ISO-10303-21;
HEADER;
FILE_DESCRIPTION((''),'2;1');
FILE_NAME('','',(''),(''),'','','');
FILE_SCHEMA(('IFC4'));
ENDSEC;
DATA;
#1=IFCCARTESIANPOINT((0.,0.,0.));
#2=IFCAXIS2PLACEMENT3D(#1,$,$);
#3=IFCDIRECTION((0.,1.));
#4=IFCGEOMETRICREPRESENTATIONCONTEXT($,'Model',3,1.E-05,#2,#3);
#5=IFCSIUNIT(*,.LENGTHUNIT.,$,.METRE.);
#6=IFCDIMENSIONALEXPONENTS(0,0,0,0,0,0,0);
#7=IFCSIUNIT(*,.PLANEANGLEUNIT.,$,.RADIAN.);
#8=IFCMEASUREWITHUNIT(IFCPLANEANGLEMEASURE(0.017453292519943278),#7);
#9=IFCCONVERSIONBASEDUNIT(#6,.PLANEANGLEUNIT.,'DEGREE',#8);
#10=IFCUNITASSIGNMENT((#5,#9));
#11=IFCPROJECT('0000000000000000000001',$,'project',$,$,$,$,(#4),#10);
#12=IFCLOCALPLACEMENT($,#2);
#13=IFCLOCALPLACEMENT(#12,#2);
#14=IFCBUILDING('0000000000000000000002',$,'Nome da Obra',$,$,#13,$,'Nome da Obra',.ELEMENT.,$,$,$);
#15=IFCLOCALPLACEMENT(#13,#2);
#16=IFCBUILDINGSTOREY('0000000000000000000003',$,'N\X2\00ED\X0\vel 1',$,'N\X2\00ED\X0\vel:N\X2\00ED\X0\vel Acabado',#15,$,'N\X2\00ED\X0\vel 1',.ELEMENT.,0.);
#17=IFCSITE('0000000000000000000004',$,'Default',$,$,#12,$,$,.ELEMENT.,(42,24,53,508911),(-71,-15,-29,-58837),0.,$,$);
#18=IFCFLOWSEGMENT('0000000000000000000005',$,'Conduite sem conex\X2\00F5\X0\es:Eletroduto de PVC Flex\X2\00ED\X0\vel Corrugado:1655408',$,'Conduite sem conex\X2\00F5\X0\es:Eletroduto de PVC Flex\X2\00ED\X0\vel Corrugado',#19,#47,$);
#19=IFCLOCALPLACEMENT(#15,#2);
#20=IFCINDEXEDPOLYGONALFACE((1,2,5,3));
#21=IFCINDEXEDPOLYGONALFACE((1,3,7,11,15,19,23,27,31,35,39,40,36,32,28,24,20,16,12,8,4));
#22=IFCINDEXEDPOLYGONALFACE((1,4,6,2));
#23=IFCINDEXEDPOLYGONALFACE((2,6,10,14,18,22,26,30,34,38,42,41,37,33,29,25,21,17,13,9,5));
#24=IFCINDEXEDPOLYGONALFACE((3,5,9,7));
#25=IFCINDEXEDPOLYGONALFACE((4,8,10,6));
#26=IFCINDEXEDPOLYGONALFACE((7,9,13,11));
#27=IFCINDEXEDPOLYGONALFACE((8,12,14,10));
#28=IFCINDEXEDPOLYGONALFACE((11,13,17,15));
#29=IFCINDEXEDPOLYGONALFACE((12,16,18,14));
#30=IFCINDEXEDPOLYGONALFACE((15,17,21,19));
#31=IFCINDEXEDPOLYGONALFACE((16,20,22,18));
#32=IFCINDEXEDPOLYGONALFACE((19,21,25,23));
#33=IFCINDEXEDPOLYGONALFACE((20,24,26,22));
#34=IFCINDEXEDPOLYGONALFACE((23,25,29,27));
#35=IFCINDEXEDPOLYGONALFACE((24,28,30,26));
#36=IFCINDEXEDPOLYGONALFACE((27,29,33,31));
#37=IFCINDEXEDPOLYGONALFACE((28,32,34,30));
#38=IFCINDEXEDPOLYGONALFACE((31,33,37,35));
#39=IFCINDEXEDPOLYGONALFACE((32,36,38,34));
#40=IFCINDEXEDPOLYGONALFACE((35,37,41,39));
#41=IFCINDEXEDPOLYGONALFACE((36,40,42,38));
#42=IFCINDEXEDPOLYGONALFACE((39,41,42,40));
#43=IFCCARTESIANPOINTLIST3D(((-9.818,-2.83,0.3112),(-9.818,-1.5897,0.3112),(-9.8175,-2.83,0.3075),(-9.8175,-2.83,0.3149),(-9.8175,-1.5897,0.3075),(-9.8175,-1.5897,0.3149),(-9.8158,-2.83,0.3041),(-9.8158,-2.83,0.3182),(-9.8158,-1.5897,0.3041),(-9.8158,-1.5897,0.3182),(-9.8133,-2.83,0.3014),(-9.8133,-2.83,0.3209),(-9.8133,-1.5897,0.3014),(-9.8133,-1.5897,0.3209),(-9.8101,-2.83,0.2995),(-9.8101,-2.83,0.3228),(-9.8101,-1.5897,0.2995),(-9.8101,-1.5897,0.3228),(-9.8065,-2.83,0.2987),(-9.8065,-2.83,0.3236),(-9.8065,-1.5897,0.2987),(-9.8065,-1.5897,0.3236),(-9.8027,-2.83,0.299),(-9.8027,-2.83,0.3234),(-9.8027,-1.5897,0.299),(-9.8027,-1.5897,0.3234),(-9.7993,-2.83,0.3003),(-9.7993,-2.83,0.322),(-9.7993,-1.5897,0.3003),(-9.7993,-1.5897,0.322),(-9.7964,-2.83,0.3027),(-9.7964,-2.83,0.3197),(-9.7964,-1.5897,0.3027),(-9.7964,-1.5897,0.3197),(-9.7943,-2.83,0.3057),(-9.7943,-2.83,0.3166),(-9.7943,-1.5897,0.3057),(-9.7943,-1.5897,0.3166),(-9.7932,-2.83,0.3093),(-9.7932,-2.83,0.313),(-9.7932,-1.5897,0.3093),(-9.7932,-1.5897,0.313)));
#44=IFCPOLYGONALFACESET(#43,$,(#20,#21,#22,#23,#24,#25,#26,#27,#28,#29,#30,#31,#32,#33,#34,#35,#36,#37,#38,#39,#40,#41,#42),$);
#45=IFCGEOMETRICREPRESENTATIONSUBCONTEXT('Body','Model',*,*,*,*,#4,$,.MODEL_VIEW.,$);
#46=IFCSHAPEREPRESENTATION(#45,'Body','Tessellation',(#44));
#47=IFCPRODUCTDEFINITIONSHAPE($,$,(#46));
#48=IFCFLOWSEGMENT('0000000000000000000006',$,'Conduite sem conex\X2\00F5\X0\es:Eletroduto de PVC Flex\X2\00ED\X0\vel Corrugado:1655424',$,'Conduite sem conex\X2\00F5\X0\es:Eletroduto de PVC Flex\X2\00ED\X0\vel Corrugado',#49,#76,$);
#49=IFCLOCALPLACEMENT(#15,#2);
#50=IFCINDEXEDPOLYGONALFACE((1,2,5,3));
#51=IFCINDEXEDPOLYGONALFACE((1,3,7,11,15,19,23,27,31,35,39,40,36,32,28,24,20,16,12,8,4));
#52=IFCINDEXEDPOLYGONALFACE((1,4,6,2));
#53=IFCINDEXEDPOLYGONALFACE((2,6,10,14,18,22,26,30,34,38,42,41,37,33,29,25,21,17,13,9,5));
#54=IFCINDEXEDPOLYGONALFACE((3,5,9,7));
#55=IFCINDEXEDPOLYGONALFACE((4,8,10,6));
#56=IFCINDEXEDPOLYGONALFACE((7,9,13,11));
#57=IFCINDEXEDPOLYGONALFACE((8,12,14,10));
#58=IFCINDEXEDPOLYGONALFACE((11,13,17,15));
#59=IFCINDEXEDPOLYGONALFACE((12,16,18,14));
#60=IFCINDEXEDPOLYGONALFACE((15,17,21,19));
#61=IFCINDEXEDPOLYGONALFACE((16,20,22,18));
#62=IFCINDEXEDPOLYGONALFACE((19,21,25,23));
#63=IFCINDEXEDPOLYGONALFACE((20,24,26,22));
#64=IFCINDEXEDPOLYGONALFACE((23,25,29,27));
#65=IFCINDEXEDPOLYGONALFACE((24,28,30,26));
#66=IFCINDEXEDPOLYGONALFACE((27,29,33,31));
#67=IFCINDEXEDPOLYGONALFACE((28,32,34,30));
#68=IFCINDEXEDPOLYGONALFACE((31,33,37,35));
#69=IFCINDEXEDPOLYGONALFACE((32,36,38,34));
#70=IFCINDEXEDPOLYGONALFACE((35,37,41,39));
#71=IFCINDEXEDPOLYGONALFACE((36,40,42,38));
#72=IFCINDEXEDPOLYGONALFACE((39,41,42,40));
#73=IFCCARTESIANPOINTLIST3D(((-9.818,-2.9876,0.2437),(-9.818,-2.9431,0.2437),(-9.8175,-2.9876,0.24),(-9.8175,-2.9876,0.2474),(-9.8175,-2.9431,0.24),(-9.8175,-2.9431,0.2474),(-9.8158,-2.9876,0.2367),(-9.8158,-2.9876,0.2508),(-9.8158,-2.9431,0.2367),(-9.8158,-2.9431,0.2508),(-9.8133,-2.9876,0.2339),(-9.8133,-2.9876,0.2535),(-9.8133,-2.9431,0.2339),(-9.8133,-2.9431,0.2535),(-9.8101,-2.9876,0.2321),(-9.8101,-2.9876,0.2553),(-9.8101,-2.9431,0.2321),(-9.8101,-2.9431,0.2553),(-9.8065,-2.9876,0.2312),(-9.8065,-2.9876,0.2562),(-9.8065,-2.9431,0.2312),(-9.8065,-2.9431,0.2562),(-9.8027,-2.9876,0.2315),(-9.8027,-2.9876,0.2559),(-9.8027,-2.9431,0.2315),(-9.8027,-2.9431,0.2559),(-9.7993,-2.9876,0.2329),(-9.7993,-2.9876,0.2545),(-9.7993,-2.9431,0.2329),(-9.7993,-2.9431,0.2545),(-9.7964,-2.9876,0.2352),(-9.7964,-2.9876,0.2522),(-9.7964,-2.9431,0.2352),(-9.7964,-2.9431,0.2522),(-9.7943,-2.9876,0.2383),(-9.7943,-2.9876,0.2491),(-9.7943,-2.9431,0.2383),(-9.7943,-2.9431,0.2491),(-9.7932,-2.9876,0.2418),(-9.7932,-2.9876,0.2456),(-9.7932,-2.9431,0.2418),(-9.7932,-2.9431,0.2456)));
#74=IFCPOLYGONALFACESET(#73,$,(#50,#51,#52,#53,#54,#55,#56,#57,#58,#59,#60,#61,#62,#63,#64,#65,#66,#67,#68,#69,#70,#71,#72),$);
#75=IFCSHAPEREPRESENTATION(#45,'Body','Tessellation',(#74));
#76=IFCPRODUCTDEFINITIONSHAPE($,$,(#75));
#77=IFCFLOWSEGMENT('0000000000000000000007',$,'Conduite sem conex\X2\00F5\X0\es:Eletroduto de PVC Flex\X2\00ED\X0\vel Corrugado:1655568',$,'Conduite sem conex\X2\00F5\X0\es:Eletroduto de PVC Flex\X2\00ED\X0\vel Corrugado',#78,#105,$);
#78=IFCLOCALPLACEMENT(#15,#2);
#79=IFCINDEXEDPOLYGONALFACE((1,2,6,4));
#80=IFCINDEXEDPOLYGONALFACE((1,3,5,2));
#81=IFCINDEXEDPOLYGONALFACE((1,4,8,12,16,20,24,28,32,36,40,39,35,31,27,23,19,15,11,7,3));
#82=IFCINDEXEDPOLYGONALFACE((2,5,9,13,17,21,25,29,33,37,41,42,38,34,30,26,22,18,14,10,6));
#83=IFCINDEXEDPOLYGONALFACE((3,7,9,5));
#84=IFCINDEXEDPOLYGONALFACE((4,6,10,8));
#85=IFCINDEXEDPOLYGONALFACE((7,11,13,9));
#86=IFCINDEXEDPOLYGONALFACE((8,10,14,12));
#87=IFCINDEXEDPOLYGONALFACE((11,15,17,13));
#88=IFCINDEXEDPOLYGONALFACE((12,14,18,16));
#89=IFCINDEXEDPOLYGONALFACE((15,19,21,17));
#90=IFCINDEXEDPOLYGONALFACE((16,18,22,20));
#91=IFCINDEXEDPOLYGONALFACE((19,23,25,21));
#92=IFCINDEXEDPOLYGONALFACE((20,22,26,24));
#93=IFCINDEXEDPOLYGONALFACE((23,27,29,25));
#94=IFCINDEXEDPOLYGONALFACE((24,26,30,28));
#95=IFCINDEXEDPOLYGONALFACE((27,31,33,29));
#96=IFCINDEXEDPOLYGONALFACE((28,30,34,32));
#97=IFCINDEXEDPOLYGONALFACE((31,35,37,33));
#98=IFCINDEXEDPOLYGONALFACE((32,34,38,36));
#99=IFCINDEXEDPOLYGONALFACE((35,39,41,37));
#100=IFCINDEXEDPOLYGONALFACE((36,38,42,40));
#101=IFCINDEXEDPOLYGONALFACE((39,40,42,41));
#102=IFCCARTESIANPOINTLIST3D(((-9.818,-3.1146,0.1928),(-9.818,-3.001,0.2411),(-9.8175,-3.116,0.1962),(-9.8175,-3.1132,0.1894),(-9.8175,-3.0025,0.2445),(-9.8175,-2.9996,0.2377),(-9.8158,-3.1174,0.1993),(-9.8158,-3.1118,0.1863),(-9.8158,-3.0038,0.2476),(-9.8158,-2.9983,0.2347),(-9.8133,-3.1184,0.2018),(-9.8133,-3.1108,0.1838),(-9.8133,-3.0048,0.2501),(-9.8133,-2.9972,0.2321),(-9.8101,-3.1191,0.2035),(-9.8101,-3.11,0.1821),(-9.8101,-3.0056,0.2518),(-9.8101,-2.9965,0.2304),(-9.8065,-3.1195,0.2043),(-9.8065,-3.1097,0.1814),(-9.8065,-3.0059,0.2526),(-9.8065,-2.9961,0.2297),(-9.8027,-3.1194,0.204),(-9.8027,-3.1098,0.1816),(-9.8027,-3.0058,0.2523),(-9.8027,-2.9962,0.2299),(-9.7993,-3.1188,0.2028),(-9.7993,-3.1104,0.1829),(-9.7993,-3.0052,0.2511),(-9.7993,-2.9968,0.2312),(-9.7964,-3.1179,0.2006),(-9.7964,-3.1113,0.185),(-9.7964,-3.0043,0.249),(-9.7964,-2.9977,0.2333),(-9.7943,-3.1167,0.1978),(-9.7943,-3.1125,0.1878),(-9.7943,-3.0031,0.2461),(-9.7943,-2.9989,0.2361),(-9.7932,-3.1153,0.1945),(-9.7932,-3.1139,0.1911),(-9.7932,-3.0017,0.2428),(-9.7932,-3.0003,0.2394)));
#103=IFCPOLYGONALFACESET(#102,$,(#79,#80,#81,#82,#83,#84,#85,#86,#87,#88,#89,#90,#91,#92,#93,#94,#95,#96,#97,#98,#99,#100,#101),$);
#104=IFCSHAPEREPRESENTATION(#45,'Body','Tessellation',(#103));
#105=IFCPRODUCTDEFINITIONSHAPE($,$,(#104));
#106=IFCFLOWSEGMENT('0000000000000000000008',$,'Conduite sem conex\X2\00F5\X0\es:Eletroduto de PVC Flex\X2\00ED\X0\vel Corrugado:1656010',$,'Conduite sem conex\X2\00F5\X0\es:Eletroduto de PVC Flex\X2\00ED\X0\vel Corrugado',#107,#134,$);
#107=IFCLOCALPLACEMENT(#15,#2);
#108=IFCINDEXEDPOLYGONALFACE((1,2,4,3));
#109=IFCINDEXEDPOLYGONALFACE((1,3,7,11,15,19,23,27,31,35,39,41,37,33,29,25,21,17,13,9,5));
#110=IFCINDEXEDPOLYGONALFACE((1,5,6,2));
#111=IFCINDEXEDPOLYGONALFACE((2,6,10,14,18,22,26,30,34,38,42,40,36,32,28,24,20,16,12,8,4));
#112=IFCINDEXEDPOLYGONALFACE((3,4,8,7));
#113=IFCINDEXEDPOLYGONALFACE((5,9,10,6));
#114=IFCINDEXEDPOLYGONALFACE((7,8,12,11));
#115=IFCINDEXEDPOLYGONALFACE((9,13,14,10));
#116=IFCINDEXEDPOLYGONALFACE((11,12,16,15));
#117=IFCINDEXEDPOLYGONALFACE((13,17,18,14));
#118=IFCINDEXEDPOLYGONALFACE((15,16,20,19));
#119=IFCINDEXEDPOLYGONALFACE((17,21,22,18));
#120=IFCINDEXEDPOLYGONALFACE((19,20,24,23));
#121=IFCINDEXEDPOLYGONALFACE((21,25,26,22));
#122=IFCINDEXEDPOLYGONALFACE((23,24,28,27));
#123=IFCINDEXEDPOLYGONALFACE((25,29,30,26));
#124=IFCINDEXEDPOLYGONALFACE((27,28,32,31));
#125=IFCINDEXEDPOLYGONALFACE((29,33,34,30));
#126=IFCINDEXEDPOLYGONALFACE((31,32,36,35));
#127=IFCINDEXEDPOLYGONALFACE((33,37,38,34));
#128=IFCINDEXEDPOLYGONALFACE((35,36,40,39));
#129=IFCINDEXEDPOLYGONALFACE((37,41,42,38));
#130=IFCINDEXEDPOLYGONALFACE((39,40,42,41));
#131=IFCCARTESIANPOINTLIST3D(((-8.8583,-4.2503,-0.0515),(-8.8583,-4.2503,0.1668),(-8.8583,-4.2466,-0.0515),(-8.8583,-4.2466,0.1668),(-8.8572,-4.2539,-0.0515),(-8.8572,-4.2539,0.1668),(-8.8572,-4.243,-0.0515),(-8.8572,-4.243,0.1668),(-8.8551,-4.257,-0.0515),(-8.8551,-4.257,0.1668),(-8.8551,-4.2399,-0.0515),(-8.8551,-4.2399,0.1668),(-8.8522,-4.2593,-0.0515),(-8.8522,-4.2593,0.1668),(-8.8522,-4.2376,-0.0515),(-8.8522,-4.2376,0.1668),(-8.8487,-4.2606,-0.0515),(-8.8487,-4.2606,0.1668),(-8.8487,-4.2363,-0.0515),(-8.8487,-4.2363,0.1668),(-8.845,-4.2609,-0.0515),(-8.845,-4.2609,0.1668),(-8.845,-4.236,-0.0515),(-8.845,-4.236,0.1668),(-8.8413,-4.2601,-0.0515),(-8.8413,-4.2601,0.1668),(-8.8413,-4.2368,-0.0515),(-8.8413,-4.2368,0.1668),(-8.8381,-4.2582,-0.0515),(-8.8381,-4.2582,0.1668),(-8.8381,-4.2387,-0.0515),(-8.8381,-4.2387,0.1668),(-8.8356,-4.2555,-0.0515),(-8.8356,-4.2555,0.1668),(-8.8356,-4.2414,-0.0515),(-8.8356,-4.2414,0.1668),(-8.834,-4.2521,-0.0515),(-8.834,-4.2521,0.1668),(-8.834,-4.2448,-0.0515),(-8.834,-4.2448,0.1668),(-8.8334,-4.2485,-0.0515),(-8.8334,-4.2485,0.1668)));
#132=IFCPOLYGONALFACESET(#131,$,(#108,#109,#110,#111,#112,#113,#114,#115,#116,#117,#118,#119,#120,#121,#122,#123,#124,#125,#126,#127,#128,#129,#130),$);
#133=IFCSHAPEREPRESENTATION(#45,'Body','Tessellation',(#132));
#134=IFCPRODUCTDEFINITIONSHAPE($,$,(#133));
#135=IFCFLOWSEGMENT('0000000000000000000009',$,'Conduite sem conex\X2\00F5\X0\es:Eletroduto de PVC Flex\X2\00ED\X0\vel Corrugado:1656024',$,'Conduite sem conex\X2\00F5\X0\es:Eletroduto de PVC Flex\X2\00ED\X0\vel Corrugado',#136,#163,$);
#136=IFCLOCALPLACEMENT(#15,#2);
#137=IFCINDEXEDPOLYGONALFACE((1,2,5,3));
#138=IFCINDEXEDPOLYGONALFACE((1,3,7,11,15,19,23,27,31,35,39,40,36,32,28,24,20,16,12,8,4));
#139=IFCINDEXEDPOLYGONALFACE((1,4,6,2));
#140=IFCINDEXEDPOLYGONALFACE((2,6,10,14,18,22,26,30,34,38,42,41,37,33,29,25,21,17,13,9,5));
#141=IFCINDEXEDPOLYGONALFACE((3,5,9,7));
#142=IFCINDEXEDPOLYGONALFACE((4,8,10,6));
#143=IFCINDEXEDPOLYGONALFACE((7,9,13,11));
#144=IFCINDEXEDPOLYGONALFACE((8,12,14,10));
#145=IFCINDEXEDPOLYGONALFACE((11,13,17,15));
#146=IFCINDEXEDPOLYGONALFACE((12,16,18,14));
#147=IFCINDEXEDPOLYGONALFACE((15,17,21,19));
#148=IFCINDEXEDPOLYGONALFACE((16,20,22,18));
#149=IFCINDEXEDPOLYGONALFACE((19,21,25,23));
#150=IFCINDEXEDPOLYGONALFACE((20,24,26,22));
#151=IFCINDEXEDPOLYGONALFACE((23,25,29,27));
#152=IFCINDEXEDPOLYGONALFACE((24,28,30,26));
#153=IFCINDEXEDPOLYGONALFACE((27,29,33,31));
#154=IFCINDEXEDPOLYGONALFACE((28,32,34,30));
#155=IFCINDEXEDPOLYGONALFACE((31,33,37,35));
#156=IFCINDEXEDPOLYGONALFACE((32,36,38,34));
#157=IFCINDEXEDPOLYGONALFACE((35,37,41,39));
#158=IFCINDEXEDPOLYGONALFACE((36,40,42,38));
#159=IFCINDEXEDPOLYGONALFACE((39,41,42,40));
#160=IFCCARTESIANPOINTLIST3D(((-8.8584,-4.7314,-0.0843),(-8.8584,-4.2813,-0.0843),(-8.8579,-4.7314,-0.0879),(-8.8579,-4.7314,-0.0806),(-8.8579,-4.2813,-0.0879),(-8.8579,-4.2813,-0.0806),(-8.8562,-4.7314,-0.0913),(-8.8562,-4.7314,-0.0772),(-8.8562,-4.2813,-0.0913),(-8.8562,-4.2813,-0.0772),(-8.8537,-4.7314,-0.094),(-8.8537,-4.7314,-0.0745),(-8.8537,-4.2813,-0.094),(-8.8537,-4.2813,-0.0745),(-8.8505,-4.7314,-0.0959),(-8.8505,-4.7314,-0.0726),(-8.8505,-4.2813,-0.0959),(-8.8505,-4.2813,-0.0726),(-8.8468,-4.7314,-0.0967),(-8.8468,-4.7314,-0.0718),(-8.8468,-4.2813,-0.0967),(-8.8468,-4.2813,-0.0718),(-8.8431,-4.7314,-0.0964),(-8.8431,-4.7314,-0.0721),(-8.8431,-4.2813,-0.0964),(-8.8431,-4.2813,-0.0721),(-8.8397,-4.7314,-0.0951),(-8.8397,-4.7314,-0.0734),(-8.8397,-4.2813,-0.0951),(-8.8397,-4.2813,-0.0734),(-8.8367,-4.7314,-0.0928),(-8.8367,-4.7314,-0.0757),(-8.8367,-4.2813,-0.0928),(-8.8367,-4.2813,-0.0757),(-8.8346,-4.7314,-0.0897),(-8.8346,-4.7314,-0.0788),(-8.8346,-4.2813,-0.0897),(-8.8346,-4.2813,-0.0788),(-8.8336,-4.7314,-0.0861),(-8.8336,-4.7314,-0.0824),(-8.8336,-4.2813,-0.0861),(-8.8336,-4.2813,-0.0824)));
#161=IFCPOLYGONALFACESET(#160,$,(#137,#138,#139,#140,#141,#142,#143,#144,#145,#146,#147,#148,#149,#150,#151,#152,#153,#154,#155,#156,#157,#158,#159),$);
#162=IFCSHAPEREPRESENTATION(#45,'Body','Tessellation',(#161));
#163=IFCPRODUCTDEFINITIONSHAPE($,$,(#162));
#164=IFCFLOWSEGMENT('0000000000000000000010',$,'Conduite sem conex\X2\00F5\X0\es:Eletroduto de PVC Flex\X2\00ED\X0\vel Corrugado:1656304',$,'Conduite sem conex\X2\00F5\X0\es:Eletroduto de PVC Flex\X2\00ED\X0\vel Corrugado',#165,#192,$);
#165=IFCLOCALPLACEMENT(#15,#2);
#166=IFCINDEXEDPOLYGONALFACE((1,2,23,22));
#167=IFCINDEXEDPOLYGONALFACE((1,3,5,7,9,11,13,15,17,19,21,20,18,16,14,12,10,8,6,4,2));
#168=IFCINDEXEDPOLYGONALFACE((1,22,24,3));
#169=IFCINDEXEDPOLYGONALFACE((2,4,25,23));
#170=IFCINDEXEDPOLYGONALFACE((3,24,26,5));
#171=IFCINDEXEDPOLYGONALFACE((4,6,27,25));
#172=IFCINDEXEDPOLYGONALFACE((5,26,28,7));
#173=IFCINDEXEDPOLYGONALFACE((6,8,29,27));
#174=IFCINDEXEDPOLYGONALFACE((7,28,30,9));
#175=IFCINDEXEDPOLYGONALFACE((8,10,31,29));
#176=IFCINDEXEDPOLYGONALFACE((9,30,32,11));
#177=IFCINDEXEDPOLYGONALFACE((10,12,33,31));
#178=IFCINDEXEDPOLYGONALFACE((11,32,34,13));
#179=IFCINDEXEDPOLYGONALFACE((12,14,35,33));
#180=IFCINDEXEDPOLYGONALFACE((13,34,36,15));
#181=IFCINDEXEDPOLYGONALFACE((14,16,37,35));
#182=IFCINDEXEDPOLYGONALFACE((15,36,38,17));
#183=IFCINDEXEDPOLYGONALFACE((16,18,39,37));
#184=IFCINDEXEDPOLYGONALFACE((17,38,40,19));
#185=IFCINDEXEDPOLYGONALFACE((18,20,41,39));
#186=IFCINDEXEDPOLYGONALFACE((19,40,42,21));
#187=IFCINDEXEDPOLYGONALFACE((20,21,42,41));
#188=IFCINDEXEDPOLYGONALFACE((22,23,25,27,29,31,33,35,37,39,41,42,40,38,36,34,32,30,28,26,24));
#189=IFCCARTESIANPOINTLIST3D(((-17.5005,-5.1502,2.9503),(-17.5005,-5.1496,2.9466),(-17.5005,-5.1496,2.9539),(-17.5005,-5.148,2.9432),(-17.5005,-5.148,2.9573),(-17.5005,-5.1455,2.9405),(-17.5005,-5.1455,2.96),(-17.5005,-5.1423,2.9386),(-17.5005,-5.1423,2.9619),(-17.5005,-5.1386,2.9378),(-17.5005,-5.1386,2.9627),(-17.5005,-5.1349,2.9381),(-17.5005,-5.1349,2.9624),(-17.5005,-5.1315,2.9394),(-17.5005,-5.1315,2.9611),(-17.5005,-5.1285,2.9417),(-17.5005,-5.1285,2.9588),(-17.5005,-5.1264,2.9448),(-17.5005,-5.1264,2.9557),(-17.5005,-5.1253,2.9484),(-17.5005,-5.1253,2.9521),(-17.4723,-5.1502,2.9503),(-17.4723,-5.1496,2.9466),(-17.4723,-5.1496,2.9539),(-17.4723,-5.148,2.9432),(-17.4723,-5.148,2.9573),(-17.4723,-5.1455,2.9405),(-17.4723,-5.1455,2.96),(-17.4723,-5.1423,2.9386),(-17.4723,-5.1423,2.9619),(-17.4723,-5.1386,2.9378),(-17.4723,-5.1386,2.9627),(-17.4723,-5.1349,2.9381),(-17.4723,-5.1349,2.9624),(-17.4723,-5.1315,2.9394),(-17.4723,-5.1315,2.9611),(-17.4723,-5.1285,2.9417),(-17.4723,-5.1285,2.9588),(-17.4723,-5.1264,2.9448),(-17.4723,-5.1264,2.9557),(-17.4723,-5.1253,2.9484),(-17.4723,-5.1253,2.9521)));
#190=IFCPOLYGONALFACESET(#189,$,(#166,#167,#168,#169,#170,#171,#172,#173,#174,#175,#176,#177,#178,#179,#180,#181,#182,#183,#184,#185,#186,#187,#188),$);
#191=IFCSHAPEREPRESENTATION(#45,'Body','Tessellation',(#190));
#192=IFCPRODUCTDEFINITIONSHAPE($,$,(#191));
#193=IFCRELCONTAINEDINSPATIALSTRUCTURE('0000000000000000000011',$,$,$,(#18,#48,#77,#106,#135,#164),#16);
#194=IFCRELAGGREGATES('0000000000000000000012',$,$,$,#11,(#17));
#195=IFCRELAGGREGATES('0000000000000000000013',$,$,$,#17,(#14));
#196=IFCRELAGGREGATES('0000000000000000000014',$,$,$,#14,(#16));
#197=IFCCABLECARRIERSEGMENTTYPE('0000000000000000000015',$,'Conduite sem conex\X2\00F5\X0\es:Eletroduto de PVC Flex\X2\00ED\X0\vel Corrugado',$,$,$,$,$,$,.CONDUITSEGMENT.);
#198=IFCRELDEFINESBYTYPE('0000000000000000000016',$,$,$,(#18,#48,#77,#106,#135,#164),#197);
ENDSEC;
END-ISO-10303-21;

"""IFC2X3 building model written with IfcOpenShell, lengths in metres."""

from ifc_helpers import new_model, entity, si_unit, converted_unit, direction, frame, frame_2d, origin, origin_2d_with_axis, place, context, subcontext, project, spatial, circle, extrude, type_object, element, save


model = new_model("IFC2X3")

# Units and contexts
model_context = context("Model", 3, precision=1e-05, world=origin(), true_north=direction((0.0, 1.0)))
body_context = subcontext(model_context, "Body", "Model", "MODEL_VIEW")
ifc_project = project(units=[si_unit("LENGTHUNIT", "METRE"), converted_unit("PLANEANGLEUNIT", "DEGREE", entity("IfcPlaneAngleMeasure", 0.017453292519943278), si_unit("PLANEANGLEUNIT", "RADIAN"), dimensions=[0, 0, 0, 0, 0, 0, 0])], contexts=[model_context])

# Site, building, storey
site_placement = place(None, origin())
site = spatial("IfcSite", under=ifc_project, at=site_placement, Name="Default", CompositionType="ELEMENT", RefLatitude=(42, 24, 53, 508911), RefLongitude=(-71, -15, -29, -58837), RefElevation=0.0)
building_placement = place(site_placement, origin())
building = spatial("IfcBuilding", under=site, at=building_placement, Name="Nome da Obra", LongName="Nome da Obra", CompositionType="ELEMENT")
storey_placement = place(building_placement, origin())
storey = spatial("IfcBuildingStorey", under=building, at=storey_placement, Name="Nível 1", ObjectType="Nível:Nível Acabado", LongName="Nível 1", CompositionType="ELEMENT", Elevation=0.0)

# Flow segments
cable_carrier_segment_type = type_object("IfcCableCarrierSegmentType", Name="Conduite sem conexões:Eletroduto de PVC Flexível Corrugado", PredefinedType="CONDUITSEGMENT")
flow_segment_1_placement = place(storey_placement, origin())
element("IfcFlowSegment", 1, at=flow_segment_1_placement, inside=storey, type_object=cable_carrier_segment_type, Name="Conduite sem conexões:Eletroduto de PVC Flexível Corrugado:1655408", ObjectType="Conduite sem conexões:Eletroduto de PVC Flexível Corrugado", context=body_context, shape_type="SweptSolid", body=[
    extrude(circle(Radius=0.0125, at=frame_2d((0.0, 0.0), x_axis=(1.0, 0.0))), frame((-9.8055, -2.83, 0.3112), z_axis=(0.000002, 1.0, 0.0), x_axis=(-1.0, 0.000002, 0.0)), (0.0, 0.0, 1.0), 1.2403),
])
flow_segment_2_placement = place(storey_placement, origin())
element("IfcFlowSegment", 2, at=flow_segment_2_placement, inside=storey, type_object=cable_carrier_segment_type, Name="Conduite sem conexões:Eletroduto de PVC Flexível Corrugado:1655424", ObjectType="Conduite sem conexões:Eletroduto de PVC Flexível Corrugado", context=body_context, shape_type="SweptSolid", body=[
    extrude(circle(Radius=0.0125, at=frame_2d((0.0, 0.0), x_axis=(1.0, 0.0))), frame((-9.8055, -2.9876, 0.2437), z_axis=(0.0, 1.0, 0.0), x_axis=(-1.0, 0.0, 0.0)), (0.0, 0.0, 1.0), 0.0445),
])
flow_segment_3_placement = place(storey_placement, origin())
element("IfcFlowSegment", 3, at=flow_segment_3_placement, inside=storey, type_object=cable_carrier_segment_type, Name="Conduite sem conexões:Eletroduto de PVC Flexível Corrugado:1655568", ObjectType="Conduite sem conexões:Eletroduto de PVC Flexível Corrugado", context=body_context, shape_type="SweptSolid", body=[
    extrude(circle(Radius=0.0125, at=origin_2d_with_axis()), frame((-9.8055, -3.1146, 0.1928), z_axis=(0.0, 0.920228, 0.391382), x_axis=(-1.0, 0.0, 0.0)), (0.0, 0.0, 1.0), 0.1234),
])
flow_segment_4_placement = place(storey_placement, origin())
element("IfcFlowSegment", 4, at=flow_segment_4_placement, inside=storey, type_object=cable_carrier_segment_type, Name="Conduite sem conexões:Eletroduto de PVC Flexível Corrugado:1656010", ObjectType="Conduite sem conexões:Eletroduto de PVC Flexível Corrugado", context=body_context, shape_type="SweptSolid", body=[
    extrude(circle(Radius=0.0125, at=frame_2d((0.0, 0.0), x_axis=(1.0, 0.0))), frame((-8.8459, -4.2485, -0.0515)), (0.0, 0.0, 1.0), 0.2182),
])
flow_segment_5_placement = place(storey_placement, origin())
element("IfcFlowSegment", 5, at=flow_segment_5_placement, inside=storey, type_object=cable_carrier_segment_type, Name="Conduite sem conexões:Eletroduto de PVC Flexível Corrugado:1656024", ObjectType="Conduite sem conexões:Eletroduto de PVC Flexível Corrugado", context=body_context, shape_type="SweptSolid", body=[
    extrude(circle(Radius=0.0125, at=frame_2d((0.0, 0.0), x_axis=(1.0, 0.0))), frame((-8.8459, -4.7314, -0.0843), z_axis=(-0.000001, 1.0, 0.0), x_axis=(-1.0, -0.000001, 0.0)), (0.0, 0.0, 1.0), 0.4501),
])
flow_segment_6_placement = place(storey_placement, origin())
element("IfcFlowSegment", 6, at=flow_segment_6_placement, inside=storey, type_object=cable_carrier_segment_type, Name="Conduite sem conexões:Eletroduto de PVC Flexível Corrugado:1656304", ObjectType="Conduite sem conexões:Eletroduto de PVC Flexível Corrugado", context=body_context, shape_type="SweptSolid", body=[
    extrude(circle(Radius=0.0125, at=frame_2d((0.0, 0.0), x_axis=(1.0, 0.0))), frame((-17.5005, -5.1377, 2.9503), z_axis=(1.0, 0.0, 0.0), x_axis=(0.0, -1.0, 0.0)), (0.0, 0.0, 1.0), 0.0282),
])

save(model, "model.ifc")
